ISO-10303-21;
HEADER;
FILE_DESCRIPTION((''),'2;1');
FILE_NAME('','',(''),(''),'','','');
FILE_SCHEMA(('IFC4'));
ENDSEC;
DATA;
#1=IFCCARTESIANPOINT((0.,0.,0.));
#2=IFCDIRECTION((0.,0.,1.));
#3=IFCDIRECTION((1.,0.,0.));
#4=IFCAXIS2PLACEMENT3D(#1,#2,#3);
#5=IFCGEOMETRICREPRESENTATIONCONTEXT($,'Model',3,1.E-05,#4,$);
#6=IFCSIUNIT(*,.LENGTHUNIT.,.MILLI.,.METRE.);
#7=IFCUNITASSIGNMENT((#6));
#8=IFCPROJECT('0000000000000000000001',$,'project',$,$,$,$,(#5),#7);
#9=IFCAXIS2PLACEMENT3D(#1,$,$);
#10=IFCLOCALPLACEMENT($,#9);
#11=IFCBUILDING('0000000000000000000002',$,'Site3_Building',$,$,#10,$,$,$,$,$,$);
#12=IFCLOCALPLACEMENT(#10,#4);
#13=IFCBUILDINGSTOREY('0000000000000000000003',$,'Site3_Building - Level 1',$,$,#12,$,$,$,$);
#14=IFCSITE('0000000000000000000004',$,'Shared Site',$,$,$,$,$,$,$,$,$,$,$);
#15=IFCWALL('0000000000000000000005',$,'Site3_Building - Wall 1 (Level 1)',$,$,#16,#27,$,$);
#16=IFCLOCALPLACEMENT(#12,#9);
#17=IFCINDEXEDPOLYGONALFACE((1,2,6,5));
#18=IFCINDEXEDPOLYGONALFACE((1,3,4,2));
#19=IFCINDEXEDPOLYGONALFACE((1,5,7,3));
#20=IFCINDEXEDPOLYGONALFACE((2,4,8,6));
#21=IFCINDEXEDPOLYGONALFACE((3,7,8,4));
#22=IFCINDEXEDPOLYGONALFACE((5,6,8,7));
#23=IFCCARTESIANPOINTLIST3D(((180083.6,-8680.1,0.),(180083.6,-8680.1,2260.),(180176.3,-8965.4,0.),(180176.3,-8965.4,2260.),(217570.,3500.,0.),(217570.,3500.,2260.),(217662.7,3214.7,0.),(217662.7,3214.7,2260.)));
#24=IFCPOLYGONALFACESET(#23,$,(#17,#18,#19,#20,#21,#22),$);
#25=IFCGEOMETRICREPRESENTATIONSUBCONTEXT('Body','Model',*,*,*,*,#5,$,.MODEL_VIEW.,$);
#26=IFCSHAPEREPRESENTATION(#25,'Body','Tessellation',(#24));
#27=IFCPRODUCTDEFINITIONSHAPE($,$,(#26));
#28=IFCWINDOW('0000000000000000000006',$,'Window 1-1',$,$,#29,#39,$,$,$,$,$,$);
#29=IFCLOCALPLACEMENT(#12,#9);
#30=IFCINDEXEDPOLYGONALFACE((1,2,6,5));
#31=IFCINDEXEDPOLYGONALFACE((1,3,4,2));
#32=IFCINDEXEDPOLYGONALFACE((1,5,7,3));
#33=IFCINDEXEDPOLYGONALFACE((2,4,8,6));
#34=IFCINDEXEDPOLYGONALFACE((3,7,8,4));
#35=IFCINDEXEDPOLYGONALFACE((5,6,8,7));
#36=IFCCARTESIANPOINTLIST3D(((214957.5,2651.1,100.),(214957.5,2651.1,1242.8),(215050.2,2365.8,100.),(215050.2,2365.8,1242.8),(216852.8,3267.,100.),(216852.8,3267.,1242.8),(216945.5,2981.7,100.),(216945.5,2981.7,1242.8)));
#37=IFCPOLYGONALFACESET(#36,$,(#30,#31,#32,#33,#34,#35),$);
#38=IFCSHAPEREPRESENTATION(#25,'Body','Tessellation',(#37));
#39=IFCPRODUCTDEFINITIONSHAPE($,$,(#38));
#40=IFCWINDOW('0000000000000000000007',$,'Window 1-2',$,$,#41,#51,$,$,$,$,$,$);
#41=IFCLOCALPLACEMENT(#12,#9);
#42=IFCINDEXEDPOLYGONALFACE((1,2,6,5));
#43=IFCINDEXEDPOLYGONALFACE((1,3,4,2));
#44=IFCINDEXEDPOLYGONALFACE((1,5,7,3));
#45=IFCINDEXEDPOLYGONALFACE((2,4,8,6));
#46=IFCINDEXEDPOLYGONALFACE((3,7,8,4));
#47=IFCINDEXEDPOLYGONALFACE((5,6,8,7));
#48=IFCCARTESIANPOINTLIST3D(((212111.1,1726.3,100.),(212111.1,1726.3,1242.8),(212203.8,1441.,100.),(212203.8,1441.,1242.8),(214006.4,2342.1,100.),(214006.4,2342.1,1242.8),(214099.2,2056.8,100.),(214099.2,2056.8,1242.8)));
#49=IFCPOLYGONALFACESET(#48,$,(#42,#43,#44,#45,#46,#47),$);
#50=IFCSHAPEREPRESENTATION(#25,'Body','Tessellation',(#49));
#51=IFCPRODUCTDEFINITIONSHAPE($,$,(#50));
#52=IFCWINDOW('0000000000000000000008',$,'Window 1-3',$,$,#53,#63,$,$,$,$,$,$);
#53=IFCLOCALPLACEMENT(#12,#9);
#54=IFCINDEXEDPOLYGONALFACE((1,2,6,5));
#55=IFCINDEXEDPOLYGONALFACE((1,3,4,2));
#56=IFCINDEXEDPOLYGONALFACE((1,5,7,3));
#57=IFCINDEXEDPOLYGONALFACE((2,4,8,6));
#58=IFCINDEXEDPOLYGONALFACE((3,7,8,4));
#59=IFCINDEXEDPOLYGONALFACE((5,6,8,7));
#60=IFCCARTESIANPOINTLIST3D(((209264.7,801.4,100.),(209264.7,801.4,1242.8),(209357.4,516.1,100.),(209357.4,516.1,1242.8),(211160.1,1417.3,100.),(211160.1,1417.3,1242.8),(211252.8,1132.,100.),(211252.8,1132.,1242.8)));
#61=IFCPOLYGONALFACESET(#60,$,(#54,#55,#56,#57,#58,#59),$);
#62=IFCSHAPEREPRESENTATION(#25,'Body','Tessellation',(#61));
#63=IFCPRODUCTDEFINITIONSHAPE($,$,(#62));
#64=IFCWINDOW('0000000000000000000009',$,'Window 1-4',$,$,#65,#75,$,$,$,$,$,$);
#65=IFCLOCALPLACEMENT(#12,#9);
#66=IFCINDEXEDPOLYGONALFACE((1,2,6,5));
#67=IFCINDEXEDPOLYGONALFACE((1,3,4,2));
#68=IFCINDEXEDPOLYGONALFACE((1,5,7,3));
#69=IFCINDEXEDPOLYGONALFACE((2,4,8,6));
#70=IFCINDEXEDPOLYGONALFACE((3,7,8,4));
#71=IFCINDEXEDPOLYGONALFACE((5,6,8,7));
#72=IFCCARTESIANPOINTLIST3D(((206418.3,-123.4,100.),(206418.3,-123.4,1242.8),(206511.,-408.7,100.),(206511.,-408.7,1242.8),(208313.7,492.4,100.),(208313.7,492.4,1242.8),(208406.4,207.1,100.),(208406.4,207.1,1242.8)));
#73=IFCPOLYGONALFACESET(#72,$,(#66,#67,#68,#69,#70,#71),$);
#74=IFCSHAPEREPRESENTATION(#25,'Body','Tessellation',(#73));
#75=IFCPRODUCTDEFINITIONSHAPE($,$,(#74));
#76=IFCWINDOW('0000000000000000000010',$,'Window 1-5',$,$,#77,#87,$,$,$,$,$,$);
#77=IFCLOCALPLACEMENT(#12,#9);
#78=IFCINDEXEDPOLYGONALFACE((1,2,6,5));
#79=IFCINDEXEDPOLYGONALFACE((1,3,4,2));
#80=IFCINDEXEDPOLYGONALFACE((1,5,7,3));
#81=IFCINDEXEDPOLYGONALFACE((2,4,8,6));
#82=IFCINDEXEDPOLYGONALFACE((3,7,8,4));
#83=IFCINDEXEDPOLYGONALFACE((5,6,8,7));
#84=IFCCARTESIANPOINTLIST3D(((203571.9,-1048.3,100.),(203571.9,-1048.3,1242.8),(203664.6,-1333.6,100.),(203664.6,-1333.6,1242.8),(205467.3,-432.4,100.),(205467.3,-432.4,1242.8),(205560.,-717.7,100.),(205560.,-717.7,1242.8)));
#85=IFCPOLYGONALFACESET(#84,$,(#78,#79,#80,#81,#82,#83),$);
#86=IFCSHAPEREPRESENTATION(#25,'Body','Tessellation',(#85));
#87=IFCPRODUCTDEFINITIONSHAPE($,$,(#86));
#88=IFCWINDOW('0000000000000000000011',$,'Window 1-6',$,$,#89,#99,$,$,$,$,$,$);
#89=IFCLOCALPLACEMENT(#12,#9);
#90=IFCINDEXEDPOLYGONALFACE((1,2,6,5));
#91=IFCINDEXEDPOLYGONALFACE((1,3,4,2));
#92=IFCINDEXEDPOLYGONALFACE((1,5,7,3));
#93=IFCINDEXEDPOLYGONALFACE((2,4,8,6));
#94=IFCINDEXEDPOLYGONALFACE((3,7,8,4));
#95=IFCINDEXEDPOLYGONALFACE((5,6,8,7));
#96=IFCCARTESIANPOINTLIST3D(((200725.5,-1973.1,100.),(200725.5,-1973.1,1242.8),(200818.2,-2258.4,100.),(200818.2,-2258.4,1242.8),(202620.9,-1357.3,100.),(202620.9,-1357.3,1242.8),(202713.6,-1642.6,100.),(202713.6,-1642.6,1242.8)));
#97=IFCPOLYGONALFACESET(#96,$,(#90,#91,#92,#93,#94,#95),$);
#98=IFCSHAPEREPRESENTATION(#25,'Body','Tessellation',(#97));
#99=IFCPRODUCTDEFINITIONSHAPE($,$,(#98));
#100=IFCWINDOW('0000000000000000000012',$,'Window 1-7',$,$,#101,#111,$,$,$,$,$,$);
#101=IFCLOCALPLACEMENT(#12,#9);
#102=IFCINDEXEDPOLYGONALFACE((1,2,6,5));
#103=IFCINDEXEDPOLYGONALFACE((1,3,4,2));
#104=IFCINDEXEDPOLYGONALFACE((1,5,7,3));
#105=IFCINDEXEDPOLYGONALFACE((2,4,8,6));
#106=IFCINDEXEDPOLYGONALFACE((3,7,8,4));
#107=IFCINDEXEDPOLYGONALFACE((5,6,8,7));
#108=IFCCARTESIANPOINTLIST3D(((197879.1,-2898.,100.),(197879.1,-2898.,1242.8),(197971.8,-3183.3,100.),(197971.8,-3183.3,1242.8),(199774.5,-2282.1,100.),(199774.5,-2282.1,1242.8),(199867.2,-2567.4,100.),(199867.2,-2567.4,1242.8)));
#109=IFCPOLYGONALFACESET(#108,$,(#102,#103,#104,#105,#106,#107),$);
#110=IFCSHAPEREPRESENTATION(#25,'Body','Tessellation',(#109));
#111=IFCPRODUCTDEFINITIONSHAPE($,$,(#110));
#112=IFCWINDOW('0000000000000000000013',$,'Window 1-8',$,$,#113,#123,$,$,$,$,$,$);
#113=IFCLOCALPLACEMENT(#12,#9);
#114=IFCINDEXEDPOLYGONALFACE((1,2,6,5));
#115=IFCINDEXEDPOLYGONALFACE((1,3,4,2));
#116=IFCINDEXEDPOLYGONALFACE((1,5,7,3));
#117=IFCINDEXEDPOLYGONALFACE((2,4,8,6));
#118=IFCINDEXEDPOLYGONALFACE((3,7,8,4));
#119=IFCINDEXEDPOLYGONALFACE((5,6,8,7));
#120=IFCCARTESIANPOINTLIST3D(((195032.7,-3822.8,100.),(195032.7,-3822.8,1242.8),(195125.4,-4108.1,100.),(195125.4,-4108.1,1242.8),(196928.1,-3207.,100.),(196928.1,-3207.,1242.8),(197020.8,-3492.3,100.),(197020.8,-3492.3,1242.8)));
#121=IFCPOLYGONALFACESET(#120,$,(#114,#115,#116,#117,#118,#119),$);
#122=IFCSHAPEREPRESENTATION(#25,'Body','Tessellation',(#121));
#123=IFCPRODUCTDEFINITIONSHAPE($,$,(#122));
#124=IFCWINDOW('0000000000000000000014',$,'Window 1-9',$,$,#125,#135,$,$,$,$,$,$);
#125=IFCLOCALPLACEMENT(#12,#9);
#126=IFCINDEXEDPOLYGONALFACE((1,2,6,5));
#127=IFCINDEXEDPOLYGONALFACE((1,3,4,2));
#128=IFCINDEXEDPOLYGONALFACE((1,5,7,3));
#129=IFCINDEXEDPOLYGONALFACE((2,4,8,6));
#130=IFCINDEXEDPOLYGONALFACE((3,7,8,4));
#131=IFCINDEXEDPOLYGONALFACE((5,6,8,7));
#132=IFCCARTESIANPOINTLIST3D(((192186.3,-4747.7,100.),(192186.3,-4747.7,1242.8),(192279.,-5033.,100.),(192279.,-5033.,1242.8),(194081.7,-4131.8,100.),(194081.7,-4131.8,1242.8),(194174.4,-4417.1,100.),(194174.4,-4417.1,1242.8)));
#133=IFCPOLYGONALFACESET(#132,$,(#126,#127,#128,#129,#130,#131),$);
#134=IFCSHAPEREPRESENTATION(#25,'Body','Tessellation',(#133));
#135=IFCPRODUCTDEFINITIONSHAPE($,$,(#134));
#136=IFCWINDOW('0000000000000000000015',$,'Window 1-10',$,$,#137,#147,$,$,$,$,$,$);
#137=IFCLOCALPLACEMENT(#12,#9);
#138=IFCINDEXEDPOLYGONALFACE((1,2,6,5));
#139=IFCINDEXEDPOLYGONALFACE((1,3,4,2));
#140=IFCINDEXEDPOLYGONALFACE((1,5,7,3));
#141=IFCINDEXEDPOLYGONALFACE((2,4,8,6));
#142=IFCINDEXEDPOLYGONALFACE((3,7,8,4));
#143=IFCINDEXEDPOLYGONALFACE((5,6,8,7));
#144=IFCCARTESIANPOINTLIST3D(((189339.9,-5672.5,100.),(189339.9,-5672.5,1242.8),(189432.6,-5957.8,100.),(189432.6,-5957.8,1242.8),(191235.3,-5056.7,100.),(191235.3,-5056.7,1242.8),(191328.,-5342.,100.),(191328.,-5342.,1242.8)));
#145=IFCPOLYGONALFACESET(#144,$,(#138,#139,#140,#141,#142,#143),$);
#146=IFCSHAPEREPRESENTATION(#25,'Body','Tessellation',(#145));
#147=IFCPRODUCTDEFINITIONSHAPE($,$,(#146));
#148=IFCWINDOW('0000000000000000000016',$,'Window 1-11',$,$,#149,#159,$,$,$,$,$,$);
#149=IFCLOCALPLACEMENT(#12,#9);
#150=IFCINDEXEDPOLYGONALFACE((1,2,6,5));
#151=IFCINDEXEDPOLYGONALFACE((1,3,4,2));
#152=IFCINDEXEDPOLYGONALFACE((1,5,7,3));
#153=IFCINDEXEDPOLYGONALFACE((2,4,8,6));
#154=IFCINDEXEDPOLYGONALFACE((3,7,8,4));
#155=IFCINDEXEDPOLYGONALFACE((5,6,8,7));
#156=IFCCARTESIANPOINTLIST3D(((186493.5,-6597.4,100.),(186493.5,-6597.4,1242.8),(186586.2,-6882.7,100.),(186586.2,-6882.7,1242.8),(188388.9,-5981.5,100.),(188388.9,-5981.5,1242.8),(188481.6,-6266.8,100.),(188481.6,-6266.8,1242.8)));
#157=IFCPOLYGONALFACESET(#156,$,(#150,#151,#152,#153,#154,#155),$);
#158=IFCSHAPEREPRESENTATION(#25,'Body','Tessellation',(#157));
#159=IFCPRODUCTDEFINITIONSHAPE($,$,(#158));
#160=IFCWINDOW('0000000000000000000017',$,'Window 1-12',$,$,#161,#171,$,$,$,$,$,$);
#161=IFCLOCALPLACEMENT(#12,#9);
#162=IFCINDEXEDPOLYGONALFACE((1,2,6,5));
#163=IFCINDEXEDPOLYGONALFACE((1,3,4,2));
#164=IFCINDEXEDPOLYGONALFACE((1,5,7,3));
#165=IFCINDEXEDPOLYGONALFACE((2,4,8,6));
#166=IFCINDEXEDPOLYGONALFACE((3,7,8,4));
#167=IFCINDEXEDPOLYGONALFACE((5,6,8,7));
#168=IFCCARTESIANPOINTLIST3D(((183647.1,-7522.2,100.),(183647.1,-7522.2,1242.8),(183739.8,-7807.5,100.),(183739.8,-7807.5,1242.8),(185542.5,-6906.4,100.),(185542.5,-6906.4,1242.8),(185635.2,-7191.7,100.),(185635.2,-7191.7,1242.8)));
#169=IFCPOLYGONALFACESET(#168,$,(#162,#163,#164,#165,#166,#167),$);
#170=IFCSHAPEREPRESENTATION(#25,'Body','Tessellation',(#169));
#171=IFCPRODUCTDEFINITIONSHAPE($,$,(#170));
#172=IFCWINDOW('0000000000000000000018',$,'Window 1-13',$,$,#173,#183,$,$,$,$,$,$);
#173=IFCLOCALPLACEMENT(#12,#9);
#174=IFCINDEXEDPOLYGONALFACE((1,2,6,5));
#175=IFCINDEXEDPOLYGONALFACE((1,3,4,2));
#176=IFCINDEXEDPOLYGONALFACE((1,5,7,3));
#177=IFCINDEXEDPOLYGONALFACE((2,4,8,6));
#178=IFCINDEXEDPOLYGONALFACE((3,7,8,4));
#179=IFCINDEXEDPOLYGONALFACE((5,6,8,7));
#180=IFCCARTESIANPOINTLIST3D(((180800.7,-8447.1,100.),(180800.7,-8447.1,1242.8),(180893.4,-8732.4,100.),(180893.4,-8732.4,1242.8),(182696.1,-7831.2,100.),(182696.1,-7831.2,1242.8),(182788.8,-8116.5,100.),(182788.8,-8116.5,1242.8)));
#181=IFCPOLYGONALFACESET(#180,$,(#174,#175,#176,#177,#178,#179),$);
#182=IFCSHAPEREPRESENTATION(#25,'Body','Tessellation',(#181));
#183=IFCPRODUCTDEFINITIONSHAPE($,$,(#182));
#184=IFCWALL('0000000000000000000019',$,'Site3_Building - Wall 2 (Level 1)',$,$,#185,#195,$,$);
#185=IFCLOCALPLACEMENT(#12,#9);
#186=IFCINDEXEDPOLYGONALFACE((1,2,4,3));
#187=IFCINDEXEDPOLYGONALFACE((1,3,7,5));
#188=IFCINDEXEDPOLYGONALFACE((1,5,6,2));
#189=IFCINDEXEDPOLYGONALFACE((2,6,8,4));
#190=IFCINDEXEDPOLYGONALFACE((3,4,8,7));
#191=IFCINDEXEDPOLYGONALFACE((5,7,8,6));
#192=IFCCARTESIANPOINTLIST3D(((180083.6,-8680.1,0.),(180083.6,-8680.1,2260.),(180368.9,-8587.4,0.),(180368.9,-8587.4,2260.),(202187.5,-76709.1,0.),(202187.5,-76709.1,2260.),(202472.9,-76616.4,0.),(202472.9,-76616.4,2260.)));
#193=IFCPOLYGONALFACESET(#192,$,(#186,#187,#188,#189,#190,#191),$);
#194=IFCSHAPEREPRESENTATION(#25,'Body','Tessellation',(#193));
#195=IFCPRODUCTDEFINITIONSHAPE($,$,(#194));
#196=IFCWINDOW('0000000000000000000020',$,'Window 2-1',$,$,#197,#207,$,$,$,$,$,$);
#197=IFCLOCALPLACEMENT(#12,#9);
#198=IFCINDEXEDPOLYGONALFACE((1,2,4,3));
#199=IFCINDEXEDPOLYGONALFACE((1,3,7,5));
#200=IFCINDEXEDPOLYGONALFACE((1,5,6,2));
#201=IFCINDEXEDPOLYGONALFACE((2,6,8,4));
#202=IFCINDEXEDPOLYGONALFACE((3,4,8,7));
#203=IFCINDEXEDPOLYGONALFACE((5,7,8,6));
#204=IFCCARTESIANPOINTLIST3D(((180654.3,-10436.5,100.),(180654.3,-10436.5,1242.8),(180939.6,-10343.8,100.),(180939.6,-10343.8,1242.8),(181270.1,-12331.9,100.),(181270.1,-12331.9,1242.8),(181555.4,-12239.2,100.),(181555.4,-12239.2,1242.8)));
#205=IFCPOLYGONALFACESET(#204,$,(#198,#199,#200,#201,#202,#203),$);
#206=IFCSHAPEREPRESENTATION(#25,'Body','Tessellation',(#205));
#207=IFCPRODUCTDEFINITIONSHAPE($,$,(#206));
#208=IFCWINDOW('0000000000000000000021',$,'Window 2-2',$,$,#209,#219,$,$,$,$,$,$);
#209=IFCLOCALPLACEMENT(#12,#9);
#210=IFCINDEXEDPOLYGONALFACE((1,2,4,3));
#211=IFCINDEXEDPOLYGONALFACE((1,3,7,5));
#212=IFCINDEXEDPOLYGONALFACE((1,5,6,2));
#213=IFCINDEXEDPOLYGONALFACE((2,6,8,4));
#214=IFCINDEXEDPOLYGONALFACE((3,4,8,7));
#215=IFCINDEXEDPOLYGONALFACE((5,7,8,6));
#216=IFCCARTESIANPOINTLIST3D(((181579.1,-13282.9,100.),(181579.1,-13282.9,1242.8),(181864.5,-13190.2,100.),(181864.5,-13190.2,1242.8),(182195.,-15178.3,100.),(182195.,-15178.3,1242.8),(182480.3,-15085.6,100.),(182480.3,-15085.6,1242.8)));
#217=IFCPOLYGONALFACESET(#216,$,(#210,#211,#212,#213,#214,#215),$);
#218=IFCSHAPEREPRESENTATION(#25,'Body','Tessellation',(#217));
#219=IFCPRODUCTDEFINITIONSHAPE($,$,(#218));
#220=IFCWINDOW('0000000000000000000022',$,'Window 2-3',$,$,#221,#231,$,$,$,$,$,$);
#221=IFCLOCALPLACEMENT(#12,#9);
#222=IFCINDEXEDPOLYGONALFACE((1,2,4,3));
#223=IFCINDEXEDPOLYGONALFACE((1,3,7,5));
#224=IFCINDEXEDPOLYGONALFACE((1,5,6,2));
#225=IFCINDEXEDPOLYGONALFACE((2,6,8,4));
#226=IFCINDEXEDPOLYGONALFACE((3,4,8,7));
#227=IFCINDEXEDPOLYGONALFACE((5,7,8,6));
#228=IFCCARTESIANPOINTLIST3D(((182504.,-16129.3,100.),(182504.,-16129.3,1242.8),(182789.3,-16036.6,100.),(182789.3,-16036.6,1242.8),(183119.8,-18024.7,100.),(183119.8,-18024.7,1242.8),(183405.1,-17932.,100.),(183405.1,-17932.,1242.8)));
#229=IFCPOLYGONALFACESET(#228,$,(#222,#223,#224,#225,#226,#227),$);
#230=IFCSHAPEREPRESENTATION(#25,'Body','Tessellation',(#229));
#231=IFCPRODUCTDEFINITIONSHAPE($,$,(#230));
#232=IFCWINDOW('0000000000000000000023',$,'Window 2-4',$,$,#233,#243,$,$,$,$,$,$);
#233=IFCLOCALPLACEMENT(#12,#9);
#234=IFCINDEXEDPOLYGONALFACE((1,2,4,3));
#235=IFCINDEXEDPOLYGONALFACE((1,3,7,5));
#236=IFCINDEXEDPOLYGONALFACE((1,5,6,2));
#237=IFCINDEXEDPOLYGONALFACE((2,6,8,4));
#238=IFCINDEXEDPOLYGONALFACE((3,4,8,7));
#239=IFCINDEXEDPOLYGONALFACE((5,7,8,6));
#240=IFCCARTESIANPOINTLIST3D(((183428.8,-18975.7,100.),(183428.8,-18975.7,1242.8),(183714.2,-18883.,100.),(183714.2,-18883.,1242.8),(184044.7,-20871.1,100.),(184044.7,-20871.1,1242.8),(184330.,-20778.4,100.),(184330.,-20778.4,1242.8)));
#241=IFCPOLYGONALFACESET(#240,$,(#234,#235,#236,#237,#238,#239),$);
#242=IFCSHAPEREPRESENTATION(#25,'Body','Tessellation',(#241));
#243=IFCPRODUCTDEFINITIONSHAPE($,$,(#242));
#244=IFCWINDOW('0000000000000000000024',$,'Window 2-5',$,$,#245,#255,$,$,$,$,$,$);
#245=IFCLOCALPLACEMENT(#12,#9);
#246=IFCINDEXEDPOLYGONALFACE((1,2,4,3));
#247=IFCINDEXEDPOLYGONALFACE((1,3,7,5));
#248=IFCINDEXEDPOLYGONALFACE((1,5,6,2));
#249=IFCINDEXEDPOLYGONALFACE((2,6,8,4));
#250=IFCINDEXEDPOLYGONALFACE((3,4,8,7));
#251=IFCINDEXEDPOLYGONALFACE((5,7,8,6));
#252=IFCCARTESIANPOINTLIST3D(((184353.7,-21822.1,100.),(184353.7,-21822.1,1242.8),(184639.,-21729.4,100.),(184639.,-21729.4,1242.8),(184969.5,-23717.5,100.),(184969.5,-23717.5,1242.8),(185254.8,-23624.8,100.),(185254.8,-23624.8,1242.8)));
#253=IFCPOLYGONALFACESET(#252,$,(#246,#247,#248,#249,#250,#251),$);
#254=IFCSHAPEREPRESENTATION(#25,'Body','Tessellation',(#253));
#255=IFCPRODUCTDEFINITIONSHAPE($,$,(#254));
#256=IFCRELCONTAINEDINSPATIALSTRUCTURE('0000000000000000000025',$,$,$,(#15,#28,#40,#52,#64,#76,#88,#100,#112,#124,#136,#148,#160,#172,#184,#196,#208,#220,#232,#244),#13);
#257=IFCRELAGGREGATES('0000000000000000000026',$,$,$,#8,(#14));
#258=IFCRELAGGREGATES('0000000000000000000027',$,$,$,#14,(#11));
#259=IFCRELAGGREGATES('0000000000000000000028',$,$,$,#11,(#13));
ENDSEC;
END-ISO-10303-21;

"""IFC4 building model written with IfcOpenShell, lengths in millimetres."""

from ifc_helpers import new_model, si_unit, frame, origin, origin_with_axes, place, context, subcontext, project, spatial, indexed_curve, outline, extrude, element, save


model = new_model("IFC4")

# Units and contexts
model_context = context("Model", 3, precision=1e-05, world=origin_with_axes())
body_context = subcontext(model_context, "Body", "Model", "MODEL_VIEW")
ifc_project = project(units=[si_unit("LENGTHUNIT", "METRE", prefix="MILLI")], contexts=[model_context])

# Site, building, storey
site = spatial("IfcSite", under=ifc_project, Name="Shared Site")
building_placement = place(None, origin())
building = spatial("IfcBuilding", under=site, at=building_placement, Name="Site3_Building")
storey_placement = place(building_placement, origin_with_axes())
storey = spatial("IfcBuildingStorey", under=building, at=storey_placement, Name="Site3_Building - Level 1")

# Wall
wall_1_placement = place(storey_placement, frame((217570.0, 3500.0, 0.0), z_axis=(0.0, 0.0, 1.0), x_axis=(-0.951057, -0.309017, 0.0)))
element("IfcWall", 1, at=wall_1_placement, inside=storey, Name="Site3_Building - Wall 1 (Level 1)", context=body_context, shape_type="SweptSolid", body=[
    extrude(outline(indexed_curve([(0.0, 0.0), (0.0, 300.0), (39415.5, 300.0), (39415.5, 0.0), (0.0, 0.0)], self_intersect=False)), origin_with_axes(), (0.0, 0.0, 1.0), 2260.0),
])

# Windows
for number, where, z_axis, x_axis, name in (
    (2, (216852.8, 3267.0, 100.0), (0.0, 0.0, 1.0), (-0.951057, -0.309017, 0.0), "Window 1-1"),
    (3, (214006.4, 2342.1, 100.0), (0.0, 0.0, 1.0), (-0.951057, -0.309017, 0.0), "Window 1-2"),
    (4, (211160.1, 1417.3, 100.0), (0.0, 0.0, 1.0), (-0.951057, -0.309017, 0.0), "Window 1-3"),
    (5, (208313.7, 492.4, 100.0), (0.0, 0.0, 1.0), (-0.951057, -0.309017, 0.0), "Window 1-4"),
    (6, (205467.3, -432.4, 100.0), (0.0, 0.0, 1.0), (-0.951057, -0.309017, 0.0), "Window 1-5"),
    (7, (202620.9, -1357.3, 100.0), (0.0, 0.0, 1.0), (-0.951057, -0.309017, 0.0), "Window 1-6"),
    (8, (199774.5, -2282.1, 100.0), (0.0, 0.0, 1.0), (-0.951057, -0.309017, 0.0), "Window 1-7"),
    (9, (196928.1, -3207.0, 100.0), (0.0, 0.0, 1.0), (-0.951057, -0.309017, 0.0), "Window 1-8"),
    (10, (194081.7, -4131.8, 100.0), (0.0, 0.0, 1.0), (-0.951057, -0.309017, 0.0), "Window 1-9"),
    (11, (191235.3, -5056.7, 100.0), (0.0, 0.0, 1.0), (-0.951057, -0.309017, 0.0), "Window 1-10"),
    (12, (188388.9, -5981.5, 100.0), (0.0, 0.0, 1.0), (-0.951057, -0.309017, 0.0), "Window 1-11"),
    (13, (185542.5, -6906.4, 100.0), (0.0, 0.0, 1.0), (-0.951057, -0.309017, 0.0), "Window 1-12"),
    (14, (182696.1, -7831.2, 100.0), (0.0, 0.0, 1.0), (-0.951057, -0.309017, 0.0), "Window 1-13"),
):
    element("IfcWindow", number, at=place(storey_placement, frame(where, z_axis=z_axis, x_axis=x_axis)), inside=storey, Name=name, context=body_context, shape_type="SweptSolid", body=[
        extrude(outline(indexed_curve([(0.0, 0.0), (0.0, 300.0), (1992.9, 300.0), (1992.9, 0.0), (0.0, 0.0)], self_intersect=False)), origin_with_axes(), (0.0, 0.0, 1.0), 1142.8),
    ])

# Wall
wall_2_placement = place(storey_placement, frame((180083.6, -8680.1, 0.0), z_axis=(0.0, 0.0, 1.0), x_axis=(0.309017, -0.951057, 0.0)))
element("IfcWall", 15, at=wall_2_placement, inside=storey, Name="Site3_Building - Wall 2 (Level 1)", context=body_context, shape_type="SweptSolid", body=[
    extrude(outline(indexed_curve([(0.0, 0.0), (0.0, 300.0), (71529.9, 300.0), (71529.9, 0.0), (0.0, 0.0)], self_intersect=False)), origin_with_axes(), (0.0, 0.0, 1.0), 2260.0),
])

# Windows
for number, where, z_axis, x_axis, name in (
    (16, (180654.3, -10436.5, 100.0), (0.0, 0.0, 1.0), (0.309017, -0.951057, 0.0), "Window 2-1"),
    (17, (181579.1, -13282.9, 100.0), (0.0, 0.0, 1.0), (0.309017, -0.951057, 0.0), "Window 2-2"),
    (18, (182504.0, -16129.3, 100.0), (0.0, 0.0, 1.0), (0.309017, -0.951057, 0.0), "Window 2-3"),
    (19, (183428.8, -18975.7, 100.0), (0.0, 0.0, 1.0), (0.309017, -0.951057, 0.0), "Window 2-4"),
    (20, (184353.7, -21822.1, 100.0), (0.0, 0.0, 1.0), (0.309017, -0.951057, 0.0), "Window 2-5"),
):
    element("IfcWindow", number, at=place(storey_placement, frame(where, z_axis=z_axis, x_axis=x_axis)), inside=storey, Name=name, context=body_context, shape_type="SweptSolid", body=[
        extrude(outline(indexed_curve([(0.0, 0.0), (0.0, 300.0), (1992.9, 300.0), (1992.9, 0.0), (0.0, 0.0)], self_intersect=False)), origin_with_axes(), (0.0, 0.0, 1.0), 1142.8),
    ])

save(model, "model.ifc")
